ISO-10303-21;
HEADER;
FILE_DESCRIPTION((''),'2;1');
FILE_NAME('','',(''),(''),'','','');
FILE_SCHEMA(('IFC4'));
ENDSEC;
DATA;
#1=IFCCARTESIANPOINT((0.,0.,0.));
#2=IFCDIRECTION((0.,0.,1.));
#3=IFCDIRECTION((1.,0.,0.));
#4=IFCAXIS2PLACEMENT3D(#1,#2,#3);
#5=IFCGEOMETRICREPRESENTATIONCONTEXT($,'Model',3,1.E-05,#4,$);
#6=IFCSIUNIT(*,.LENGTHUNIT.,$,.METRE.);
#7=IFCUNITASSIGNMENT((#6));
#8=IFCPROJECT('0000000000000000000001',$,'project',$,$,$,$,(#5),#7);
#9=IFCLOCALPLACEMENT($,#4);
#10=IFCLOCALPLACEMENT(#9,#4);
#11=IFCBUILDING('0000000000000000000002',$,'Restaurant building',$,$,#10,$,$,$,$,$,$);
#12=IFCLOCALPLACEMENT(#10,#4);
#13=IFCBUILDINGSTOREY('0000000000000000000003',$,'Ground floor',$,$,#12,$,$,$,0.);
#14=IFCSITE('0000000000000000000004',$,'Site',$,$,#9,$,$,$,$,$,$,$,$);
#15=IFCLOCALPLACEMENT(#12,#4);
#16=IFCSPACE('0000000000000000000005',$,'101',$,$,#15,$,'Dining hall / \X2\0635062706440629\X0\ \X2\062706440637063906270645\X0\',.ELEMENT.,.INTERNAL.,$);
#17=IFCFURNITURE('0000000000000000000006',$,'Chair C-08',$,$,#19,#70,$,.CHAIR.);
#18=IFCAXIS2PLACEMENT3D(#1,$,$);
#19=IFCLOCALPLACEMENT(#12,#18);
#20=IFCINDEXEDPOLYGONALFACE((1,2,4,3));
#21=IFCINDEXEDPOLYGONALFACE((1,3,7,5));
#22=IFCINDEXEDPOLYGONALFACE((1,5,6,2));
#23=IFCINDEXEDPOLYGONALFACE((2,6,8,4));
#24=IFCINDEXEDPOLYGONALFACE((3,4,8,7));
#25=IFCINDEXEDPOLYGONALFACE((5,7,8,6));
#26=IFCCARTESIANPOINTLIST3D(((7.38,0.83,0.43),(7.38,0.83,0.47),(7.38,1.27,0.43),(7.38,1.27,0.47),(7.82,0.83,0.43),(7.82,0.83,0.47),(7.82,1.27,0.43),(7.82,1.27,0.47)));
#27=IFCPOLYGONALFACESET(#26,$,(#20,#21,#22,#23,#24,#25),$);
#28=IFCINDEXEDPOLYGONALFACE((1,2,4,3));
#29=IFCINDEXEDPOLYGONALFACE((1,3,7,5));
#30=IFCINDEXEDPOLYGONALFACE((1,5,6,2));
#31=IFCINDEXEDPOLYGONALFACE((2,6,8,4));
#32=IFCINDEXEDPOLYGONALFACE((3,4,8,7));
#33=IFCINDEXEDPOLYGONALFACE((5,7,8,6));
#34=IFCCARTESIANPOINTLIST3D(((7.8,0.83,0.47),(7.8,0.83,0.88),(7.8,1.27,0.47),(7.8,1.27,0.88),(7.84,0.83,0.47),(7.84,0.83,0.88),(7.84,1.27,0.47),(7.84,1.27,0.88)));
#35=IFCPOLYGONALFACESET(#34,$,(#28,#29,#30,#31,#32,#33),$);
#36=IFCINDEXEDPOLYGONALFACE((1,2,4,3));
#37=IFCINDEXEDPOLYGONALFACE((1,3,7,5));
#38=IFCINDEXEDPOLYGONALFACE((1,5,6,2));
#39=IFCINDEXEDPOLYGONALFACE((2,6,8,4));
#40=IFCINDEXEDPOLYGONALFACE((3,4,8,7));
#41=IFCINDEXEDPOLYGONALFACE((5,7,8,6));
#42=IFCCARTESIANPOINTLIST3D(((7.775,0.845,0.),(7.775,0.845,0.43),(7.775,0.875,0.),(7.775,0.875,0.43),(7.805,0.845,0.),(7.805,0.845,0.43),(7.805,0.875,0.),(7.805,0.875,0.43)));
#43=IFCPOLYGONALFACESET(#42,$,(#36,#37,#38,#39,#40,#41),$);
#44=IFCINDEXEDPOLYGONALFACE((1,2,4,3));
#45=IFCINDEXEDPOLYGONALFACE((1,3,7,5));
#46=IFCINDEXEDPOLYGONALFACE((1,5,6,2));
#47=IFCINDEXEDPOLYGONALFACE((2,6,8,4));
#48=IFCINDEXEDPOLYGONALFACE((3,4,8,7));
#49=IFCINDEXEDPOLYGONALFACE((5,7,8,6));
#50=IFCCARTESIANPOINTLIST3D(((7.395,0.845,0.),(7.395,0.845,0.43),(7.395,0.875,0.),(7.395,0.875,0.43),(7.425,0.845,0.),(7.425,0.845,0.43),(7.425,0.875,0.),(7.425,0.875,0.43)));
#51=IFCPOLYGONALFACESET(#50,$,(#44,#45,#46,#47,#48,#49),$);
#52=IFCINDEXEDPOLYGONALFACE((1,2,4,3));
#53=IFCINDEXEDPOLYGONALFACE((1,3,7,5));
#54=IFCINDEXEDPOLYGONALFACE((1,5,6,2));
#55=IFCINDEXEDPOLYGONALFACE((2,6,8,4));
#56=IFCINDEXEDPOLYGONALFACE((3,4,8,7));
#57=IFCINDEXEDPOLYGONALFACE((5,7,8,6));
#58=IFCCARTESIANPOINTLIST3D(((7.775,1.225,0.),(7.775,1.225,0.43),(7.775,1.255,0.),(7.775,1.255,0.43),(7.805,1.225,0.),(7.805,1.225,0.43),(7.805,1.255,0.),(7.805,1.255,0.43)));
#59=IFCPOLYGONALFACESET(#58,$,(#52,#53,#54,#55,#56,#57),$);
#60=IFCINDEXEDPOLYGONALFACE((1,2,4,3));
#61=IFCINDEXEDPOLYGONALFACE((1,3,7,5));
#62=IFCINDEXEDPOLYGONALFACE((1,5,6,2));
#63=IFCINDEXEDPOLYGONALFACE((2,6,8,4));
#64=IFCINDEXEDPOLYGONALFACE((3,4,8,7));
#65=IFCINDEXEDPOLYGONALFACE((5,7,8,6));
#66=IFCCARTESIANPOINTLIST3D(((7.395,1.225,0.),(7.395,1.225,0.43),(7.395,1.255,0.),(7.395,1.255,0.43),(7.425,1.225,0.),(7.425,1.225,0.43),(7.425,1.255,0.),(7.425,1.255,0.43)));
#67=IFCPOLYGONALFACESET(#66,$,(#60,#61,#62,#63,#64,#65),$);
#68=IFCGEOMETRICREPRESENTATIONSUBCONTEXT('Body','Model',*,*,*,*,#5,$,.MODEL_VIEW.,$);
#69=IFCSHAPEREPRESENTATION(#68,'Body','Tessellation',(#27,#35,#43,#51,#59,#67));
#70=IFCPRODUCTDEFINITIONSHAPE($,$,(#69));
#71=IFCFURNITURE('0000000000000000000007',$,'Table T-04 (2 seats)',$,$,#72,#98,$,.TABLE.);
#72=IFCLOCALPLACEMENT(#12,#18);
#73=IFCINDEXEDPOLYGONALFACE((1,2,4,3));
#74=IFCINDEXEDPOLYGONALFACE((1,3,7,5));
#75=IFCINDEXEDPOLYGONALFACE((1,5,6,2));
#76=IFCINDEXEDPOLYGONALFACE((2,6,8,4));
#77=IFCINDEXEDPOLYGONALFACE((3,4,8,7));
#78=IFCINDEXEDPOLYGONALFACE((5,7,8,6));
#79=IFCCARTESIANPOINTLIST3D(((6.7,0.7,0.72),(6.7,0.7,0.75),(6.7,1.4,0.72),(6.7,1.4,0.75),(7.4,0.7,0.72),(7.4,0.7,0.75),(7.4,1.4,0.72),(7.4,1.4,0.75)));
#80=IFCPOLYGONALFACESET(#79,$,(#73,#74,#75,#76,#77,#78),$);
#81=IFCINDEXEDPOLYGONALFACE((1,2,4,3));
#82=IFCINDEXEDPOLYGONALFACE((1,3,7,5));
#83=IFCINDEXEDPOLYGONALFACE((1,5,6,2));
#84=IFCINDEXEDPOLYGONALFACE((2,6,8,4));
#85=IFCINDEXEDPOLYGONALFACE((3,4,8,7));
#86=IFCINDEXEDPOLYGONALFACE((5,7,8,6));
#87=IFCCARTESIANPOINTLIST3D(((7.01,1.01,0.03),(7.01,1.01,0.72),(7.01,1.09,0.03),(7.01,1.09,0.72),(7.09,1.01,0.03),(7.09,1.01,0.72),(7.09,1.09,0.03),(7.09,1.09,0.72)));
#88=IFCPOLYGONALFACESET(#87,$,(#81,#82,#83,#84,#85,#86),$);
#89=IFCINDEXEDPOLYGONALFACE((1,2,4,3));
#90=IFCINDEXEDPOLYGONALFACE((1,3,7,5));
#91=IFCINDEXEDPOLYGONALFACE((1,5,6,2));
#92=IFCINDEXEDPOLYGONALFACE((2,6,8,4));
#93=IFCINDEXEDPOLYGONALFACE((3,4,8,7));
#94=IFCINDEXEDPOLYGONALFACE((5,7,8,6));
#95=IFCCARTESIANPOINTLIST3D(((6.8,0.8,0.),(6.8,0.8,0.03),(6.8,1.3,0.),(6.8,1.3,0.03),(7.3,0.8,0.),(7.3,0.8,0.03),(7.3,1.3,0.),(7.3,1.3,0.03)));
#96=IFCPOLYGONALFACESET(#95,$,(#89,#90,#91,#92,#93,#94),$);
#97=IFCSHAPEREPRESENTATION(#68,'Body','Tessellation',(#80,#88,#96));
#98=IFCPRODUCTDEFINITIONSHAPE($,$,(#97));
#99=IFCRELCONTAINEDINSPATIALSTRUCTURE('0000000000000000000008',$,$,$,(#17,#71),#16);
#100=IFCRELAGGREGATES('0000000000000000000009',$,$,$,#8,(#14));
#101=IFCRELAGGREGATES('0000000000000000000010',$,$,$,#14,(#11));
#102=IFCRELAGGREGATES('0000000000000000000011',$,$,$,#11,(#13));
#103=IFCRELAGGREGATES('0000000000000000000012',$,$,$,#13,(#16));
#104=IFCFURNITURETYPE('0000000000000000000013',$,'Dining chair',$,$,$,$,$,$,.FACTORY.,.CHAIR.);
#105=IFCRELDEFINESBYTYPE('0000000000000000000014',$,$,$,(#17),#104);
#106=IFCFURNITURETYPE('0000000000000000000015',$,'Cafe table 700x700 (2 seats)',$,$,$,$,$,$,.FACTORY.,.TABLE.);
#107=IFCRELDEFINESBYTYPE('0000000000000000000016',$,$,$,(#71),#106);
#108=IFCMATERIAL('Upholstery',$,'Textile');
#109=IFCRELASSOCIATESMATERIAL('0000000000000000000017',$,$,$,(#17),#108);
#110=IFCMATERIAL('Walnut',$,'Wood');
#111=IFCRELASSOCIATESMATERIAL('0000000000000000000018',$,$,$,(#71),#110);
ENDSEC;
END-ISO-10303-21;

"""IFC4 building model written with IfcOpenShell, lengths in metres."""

from ifc_helpers import new_model, si_unit, frame, origin, origin_with_axes, origin_2d, place, context, subcontext, project, spatial, rectangle, extrude, source, transform, mapped, material, type_object, type_shapes, element, save


model = new_model("IFC4")

# Units and contexts
model_context = context("Model", 3, precision=1e-05, world=origin_with_axes())
body_context = subcontext(model_context, "Body", "Model", "MODEL_VIEW")
ifc_project = project(units=[si_unit("LENGTHUNIT", "METRE")], contexts=[model_context])

# Site, building, storey
site_placement = place(None, origin_with_axes())
site = spatial("IfcSite", under=ifc_project, at=site_placement, Name="Site")
building_placement = place(site_placement, origin_with_axes())
building = spatial("IfcBuilding", under=site, at=building_placement, Name="Restaurant building")
storey_placement = place(building_placement, origin_with_axes())
storey = spatial("IfcBuildingStorey", under=building, at=storey_placement, Name="Ground floor", Elevation=0.0)

# Shared definitions
space_placement = place(storey_placement, origin_with_axes())
space = spatial("IfcSpace", under=storey, at=space_placement, Name="101", LongName="Dining hall / صالة الطعام", CompositionType="ELEMENT", PredefinedType="INTERNAL")

# Furniture
ifc_material_1 = material(Name="Upholstery", Category="Textile")
furniture_type_1 = type_object("IfcFurnitureType", Name="Dining chair", AssemblyPlace="FACTORY", PredefinedType="CHAIR")
shared_shape_1 = source(origin(), body_context, "Body", "SweptSolid", [
    extrude(rectangle(XDim=0.44, YDim=0.44, at=origin_2d()), frame((0.0, 0.0, 0.43)), (0.0, 0.0, 1.0), 0.04),
    extrude(rectangle(XDim=0.44, YDim=0.04, at=origin_2d()), frame((0.0, -0.22, 0.47)), (0.0, 0.0, 1.0), 0.41),
    extrude(rectangle(XDim=0.03, YDim=0.03, at=origin_2d()), frame((-0.19, -0.19, 0.0)), (0.0, 0.0, 1.0), 0.43),
    extrude(rectangle(XDim=0.03, YDim=0.03, at=origin_2d()), frame((-0.19, 0.19, 0.0)), (0.0, 0.0, 1.0), 0.43),
    extrude(rectangle(XDim=0.03, YDim=0.03, at=origin_2d()), frame((0.19, -0.19, 0.0)), (0.0, 0.0, 1.0), 0.43),
    extrude(rectangle(XDim=0.03, YDim=0.03, at=origin_2d()), frame((0.19, 0.19, 0.0)), (0.0, 0.0, 1.0), 0.43),
])
type_shapes(furniture_type_1, [shared_shape_1])
furniture_1_placement = place(storey_placement, frame((7.6, 1.05, 0.0), z_axis=(0.0, 0.0, 1.0), x_axis=(0.0, 1.0, 0.0)))
element("IfcFurniture", 1, at=furniture_1_placement, inside=space, type_object=furniture_type_1, material=ifc_material_1, Name="Chair C-08", PredefinedType="CHAIR", context=body_context, shape_type="MappedRepresentation", body=[
    mapped(shared_shape_1, transform((0.0, 0.0, 0.0))),
])
ifc_material_2 = material(Name="Walnut", Category="Wood")
furniture_type_2 = type_object("IfcFurnitureType", Name="Cafe table 700x700 (2 seats)", AssemblyPlace="FACTORY", PredefinedType="TABLE")
shared_shape_2 = source(origin(), body_context, "Body", "SweptSolid", [
    extrude(rectangle(XDim=0.7, YDim=0.7, at=origin_2d()), frame((0.0, 0.0, 0.72)), (0.0, 0.0, 1.0), 0.03),
    extrude(rectangle(XDim=0.08, YDim=0.08, at=origin_2d()), frame((0.0, 0.0, 0.03)), (0.0, 0.0, 1.0), 0.69),
    extrude(rectangle(XDim=0.5, YDim=0.5, at=origin_2d()), origin(), (0.0, 0.0, 1.0), 0.03),
])
type_shapes(furniture_type_2, [shared_shape_2])
furniture_2_placement = place(storey_placement, frame((7.05, 1.05, 0.0)))
element("IfcFurniture", 2, at=furniture_2_placement, inside=space, type_object=furniture_type_2, material=ifc_material_2, Name="Table T-04 (2 seats)", PredefinedType="TABLE", context=body_context, shape_type="MappedRepresentation", body=[
    mapped(shared_shape_2, transform((0.0, 0.0, 0.0))),
])

save(model, "model.ifc")
